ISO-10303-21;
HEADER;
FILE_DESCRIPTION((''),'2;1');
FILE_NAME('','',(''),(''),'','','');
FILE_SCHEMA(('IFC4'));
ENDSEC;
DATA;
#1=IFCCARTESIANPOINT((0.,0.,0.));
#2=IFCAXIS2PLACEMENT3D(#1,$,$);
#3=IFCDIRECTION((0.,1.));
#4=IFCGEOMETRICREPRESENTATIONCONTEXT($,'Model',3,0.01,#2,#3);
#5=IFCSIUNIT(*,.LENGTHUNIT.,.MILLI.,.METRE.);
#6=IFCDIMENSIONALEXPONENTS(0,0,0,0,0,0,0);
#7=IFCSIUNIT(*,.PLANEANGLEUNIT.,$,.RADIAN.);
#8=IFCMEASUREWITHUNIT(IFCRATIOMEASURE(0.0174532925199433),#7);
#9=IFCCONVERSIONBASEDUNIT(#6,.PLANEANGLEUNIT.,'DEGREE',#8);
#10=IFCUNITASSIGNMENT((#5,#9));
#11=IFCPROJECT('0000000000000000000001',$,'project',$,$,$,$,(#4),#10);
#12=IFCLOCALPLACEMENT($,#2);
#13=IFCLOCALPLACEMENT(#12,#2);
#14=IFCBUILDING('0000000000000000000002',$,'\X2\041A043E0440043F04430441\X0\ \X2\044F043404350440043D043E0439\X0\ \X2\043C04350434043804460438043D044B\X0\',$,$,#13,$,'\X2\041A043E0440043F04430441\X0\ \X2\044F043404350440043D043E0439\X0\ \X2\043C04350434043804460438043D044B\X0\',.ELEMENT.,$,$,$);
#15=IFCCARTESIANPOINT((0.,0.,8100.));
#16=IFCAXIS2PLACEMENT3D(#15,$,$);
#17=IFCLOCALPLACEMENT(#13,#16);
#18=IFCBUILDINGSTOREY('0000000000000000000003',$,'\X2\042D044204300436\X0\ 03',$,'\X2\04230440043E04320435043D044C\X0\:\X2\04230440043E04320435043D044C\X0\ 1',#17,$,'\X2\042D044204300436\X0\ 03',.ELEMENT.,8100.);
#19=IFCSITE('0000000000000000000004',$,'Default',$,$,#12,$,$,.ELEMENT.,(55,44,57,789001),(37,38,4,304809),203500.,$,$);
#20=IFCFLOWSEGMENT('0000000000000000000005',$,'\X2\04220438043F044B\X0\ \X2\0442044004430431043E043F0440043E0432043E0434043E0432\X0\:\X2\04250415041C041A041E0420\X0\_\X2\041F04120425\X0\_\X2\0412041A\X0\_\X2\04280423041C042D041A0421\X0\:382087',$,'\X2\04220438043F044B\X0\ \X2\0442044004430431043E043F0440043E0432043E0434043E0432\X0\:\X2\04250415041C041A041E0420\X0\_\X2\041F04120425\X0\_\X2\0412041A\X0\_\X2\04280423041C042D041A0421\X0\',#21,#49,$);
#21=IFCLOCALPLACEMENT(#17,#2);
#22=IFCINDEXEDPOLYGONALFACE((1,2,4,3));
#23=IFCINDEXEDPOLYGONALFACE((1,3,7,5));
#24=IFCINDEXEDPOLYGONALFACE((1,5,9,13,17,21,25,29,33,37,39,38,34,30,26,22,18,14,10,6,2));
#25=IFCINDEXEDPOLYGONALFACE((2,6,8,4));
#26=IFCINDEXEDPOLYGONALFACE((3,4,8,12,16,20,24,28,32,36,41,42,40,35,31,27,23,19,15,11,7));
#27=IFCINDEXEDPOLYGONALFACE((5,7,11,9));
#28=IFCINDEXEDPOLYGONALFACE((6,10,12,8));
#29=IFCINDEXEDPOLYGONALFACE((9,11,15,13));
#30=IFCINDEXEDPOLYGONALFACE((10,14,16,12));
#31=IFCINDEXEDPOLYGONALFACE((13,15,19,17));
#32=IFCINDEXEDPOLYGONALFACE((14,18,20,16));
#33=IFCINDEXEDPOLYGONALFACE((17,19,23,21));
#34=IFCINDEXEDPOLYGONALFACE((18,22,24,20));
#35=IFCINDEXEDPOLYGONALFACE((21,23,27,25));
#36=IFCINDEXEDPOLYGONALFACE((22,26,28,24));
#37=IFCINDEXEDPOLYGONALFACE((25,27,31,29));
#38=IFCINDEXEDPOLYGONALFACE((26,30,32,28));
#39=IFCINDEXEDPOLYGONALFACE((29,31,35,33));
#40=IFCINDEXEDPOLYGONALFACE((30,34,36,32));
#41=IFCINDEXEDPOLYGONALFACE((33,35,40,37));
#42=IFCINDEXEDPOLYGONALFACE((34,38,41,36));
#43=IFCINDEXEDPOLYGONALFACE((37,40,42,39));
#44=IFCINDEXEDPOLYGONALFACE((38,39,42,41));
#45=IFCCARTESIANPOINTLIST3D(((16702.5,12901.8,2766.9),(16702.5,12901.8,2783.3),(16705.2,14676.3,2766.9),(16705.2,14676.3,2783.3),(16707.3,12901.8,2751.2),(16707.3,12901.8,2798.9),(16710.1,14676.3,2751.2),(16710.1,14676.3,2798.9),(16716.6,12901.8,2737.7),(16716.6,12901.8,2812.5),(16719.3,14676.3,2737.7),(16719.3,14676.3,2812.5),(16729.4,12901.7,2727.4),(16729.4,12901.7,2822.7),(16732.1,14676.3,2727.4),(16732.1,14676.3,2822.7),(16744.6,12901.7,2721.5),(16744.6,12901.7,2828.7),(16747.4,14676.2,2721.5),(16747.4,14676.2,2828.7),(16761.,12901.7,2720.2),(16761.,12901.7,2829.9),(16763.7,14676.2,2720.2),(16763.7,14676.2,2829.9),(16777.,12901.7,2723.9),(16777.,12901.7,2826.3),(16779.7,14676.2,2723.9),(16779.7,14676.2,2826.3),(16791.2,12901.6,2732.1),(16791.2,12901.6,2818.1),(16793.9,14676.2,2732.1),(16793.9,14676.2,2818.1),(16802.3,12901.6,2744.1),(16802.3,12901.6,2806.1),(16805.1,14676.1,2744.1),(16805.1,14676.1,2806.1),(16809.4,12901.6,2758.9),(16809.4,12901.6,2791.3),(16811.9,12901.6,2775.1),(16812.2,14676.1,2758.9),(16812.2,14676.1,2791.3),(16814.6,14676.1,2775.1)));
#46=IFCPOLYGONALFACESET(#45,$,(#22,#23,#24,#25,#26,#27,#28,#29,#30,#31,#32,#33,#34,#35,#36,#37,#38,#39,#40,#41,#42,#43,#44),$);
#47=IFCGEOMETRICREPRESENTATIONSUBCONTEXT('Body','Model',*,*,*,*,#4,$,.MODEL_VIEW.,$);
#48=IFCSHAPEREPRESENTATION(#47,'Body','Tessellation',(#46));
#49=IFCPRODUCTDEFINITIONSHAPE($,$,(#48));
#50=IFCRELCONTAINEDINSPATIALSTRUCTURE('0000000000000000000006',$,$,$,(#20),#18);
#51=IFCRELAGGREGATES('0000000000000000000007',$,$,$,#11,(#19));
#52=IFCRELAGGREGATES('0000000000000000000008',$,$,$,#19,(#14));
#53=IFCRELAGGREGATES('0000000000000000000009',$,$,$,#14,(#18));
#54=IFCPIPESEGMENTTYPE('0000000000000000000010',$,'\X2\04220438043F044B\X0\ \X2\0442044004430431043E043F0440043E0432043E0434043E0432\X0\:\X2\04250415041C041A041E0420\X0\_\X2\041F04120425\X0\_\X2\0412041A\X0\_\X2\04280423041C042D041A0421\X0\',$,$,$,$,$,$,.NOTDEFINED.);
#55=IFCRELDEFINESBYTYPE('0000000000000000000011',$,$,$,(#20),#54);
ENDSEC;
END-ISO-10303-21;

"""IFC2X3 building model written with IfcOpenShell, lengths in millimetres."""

from ifc_helpers import new_model, entity, si_unit, converted_unit, direction, frame, origin, origin_2d_with_axis, place, context, subcontext, project, spatial, circle, extrude, type_object, element, save


model = new_model("IFC2X3")

# Units and contexts
model_context = context("Model", 3, precision=0.01, world=origin(), true_north=direction((0.0, 1.0)))
body_context = subcontext(model_context, "Body", "Model", "MODEL_VIEW")
ifc_project = project(units=[si_unit("LENGTHUNIT", "METRE", prefix="MILLI"), converted_unit("PLANEANGLEUNIT", "DEGREE", entity("IfcRatioMeasure", 0.0174532925199433), si_unit("PLANEANGLEUNIT", "RADIAN"), dimensions=[0, 0, 0, 0, 0, 0, 0])], contexts=[model_context])

# Site, building, storey
site_placement = place(None, origin())
site = spatial("IfcSite", under=ifc_project, at=site_placement, Name="Default", CompositionType="ELEMENT", RefLatitude=(55, 44, 57, 789001), RefLongitude=(37, 38, 4, 304809), RefElevation=203500.0)
building_placement = place(site_placement, origin())
building = spatial("IfcBuilding", under=site, at=building_placement, Name="Корпус ядерной медицины", LongName="Корпус ядерной медицины", CompositionType="ELEMENT")
storey_placement = place(building_placement, frame((0.0, 0.0, 8100.0)))
storey = spatial("IfcBuildingStorey", under=building, at=storey_placement, Name="Этаж 03", ObjectType="Уровень:Уровень 1", LongName="Этаж 03", CompositionType="ELEMENT", Elevation=8100.0)

# Flow segment
pipe_segment_type = type_object("IfcPipeSegmentType", Name="Типы трубопроводов:ХЕМКОР_ПВХ_ВК_ШУМЭКС", PredefinedType="NOTDEFINED")
flow_segment_1_placement = place(storey_placement, frame((16700.3, 12901.6, 2718.5)))
element("IfcFlowSegment", 1, at=flow_segment_1_placement, inside=storey, type_object=pipe_segment_type, Name="Типы трубопроводов:ХЕМКОР_ПВХ_ВК_ШУМЭКС:382087", ObjectType="Типы трубопроводов:ХЕМКОР_ПВХ_ВК_ШУМЭКС", context=body_context, shape_type="SweptSolid", body=[
    extrude(circle(Radius=55.0, at=origin_2d_with_axis()), frame((56.6, 0.1, 56.6), z_axis=(0.001547, 0.999999, 0.0), x_axis=(0.999999, -0.001547, 0.0)), (0.0, 0.0, 1.0), 1774.5),
])

save(model, "model.ifc")
